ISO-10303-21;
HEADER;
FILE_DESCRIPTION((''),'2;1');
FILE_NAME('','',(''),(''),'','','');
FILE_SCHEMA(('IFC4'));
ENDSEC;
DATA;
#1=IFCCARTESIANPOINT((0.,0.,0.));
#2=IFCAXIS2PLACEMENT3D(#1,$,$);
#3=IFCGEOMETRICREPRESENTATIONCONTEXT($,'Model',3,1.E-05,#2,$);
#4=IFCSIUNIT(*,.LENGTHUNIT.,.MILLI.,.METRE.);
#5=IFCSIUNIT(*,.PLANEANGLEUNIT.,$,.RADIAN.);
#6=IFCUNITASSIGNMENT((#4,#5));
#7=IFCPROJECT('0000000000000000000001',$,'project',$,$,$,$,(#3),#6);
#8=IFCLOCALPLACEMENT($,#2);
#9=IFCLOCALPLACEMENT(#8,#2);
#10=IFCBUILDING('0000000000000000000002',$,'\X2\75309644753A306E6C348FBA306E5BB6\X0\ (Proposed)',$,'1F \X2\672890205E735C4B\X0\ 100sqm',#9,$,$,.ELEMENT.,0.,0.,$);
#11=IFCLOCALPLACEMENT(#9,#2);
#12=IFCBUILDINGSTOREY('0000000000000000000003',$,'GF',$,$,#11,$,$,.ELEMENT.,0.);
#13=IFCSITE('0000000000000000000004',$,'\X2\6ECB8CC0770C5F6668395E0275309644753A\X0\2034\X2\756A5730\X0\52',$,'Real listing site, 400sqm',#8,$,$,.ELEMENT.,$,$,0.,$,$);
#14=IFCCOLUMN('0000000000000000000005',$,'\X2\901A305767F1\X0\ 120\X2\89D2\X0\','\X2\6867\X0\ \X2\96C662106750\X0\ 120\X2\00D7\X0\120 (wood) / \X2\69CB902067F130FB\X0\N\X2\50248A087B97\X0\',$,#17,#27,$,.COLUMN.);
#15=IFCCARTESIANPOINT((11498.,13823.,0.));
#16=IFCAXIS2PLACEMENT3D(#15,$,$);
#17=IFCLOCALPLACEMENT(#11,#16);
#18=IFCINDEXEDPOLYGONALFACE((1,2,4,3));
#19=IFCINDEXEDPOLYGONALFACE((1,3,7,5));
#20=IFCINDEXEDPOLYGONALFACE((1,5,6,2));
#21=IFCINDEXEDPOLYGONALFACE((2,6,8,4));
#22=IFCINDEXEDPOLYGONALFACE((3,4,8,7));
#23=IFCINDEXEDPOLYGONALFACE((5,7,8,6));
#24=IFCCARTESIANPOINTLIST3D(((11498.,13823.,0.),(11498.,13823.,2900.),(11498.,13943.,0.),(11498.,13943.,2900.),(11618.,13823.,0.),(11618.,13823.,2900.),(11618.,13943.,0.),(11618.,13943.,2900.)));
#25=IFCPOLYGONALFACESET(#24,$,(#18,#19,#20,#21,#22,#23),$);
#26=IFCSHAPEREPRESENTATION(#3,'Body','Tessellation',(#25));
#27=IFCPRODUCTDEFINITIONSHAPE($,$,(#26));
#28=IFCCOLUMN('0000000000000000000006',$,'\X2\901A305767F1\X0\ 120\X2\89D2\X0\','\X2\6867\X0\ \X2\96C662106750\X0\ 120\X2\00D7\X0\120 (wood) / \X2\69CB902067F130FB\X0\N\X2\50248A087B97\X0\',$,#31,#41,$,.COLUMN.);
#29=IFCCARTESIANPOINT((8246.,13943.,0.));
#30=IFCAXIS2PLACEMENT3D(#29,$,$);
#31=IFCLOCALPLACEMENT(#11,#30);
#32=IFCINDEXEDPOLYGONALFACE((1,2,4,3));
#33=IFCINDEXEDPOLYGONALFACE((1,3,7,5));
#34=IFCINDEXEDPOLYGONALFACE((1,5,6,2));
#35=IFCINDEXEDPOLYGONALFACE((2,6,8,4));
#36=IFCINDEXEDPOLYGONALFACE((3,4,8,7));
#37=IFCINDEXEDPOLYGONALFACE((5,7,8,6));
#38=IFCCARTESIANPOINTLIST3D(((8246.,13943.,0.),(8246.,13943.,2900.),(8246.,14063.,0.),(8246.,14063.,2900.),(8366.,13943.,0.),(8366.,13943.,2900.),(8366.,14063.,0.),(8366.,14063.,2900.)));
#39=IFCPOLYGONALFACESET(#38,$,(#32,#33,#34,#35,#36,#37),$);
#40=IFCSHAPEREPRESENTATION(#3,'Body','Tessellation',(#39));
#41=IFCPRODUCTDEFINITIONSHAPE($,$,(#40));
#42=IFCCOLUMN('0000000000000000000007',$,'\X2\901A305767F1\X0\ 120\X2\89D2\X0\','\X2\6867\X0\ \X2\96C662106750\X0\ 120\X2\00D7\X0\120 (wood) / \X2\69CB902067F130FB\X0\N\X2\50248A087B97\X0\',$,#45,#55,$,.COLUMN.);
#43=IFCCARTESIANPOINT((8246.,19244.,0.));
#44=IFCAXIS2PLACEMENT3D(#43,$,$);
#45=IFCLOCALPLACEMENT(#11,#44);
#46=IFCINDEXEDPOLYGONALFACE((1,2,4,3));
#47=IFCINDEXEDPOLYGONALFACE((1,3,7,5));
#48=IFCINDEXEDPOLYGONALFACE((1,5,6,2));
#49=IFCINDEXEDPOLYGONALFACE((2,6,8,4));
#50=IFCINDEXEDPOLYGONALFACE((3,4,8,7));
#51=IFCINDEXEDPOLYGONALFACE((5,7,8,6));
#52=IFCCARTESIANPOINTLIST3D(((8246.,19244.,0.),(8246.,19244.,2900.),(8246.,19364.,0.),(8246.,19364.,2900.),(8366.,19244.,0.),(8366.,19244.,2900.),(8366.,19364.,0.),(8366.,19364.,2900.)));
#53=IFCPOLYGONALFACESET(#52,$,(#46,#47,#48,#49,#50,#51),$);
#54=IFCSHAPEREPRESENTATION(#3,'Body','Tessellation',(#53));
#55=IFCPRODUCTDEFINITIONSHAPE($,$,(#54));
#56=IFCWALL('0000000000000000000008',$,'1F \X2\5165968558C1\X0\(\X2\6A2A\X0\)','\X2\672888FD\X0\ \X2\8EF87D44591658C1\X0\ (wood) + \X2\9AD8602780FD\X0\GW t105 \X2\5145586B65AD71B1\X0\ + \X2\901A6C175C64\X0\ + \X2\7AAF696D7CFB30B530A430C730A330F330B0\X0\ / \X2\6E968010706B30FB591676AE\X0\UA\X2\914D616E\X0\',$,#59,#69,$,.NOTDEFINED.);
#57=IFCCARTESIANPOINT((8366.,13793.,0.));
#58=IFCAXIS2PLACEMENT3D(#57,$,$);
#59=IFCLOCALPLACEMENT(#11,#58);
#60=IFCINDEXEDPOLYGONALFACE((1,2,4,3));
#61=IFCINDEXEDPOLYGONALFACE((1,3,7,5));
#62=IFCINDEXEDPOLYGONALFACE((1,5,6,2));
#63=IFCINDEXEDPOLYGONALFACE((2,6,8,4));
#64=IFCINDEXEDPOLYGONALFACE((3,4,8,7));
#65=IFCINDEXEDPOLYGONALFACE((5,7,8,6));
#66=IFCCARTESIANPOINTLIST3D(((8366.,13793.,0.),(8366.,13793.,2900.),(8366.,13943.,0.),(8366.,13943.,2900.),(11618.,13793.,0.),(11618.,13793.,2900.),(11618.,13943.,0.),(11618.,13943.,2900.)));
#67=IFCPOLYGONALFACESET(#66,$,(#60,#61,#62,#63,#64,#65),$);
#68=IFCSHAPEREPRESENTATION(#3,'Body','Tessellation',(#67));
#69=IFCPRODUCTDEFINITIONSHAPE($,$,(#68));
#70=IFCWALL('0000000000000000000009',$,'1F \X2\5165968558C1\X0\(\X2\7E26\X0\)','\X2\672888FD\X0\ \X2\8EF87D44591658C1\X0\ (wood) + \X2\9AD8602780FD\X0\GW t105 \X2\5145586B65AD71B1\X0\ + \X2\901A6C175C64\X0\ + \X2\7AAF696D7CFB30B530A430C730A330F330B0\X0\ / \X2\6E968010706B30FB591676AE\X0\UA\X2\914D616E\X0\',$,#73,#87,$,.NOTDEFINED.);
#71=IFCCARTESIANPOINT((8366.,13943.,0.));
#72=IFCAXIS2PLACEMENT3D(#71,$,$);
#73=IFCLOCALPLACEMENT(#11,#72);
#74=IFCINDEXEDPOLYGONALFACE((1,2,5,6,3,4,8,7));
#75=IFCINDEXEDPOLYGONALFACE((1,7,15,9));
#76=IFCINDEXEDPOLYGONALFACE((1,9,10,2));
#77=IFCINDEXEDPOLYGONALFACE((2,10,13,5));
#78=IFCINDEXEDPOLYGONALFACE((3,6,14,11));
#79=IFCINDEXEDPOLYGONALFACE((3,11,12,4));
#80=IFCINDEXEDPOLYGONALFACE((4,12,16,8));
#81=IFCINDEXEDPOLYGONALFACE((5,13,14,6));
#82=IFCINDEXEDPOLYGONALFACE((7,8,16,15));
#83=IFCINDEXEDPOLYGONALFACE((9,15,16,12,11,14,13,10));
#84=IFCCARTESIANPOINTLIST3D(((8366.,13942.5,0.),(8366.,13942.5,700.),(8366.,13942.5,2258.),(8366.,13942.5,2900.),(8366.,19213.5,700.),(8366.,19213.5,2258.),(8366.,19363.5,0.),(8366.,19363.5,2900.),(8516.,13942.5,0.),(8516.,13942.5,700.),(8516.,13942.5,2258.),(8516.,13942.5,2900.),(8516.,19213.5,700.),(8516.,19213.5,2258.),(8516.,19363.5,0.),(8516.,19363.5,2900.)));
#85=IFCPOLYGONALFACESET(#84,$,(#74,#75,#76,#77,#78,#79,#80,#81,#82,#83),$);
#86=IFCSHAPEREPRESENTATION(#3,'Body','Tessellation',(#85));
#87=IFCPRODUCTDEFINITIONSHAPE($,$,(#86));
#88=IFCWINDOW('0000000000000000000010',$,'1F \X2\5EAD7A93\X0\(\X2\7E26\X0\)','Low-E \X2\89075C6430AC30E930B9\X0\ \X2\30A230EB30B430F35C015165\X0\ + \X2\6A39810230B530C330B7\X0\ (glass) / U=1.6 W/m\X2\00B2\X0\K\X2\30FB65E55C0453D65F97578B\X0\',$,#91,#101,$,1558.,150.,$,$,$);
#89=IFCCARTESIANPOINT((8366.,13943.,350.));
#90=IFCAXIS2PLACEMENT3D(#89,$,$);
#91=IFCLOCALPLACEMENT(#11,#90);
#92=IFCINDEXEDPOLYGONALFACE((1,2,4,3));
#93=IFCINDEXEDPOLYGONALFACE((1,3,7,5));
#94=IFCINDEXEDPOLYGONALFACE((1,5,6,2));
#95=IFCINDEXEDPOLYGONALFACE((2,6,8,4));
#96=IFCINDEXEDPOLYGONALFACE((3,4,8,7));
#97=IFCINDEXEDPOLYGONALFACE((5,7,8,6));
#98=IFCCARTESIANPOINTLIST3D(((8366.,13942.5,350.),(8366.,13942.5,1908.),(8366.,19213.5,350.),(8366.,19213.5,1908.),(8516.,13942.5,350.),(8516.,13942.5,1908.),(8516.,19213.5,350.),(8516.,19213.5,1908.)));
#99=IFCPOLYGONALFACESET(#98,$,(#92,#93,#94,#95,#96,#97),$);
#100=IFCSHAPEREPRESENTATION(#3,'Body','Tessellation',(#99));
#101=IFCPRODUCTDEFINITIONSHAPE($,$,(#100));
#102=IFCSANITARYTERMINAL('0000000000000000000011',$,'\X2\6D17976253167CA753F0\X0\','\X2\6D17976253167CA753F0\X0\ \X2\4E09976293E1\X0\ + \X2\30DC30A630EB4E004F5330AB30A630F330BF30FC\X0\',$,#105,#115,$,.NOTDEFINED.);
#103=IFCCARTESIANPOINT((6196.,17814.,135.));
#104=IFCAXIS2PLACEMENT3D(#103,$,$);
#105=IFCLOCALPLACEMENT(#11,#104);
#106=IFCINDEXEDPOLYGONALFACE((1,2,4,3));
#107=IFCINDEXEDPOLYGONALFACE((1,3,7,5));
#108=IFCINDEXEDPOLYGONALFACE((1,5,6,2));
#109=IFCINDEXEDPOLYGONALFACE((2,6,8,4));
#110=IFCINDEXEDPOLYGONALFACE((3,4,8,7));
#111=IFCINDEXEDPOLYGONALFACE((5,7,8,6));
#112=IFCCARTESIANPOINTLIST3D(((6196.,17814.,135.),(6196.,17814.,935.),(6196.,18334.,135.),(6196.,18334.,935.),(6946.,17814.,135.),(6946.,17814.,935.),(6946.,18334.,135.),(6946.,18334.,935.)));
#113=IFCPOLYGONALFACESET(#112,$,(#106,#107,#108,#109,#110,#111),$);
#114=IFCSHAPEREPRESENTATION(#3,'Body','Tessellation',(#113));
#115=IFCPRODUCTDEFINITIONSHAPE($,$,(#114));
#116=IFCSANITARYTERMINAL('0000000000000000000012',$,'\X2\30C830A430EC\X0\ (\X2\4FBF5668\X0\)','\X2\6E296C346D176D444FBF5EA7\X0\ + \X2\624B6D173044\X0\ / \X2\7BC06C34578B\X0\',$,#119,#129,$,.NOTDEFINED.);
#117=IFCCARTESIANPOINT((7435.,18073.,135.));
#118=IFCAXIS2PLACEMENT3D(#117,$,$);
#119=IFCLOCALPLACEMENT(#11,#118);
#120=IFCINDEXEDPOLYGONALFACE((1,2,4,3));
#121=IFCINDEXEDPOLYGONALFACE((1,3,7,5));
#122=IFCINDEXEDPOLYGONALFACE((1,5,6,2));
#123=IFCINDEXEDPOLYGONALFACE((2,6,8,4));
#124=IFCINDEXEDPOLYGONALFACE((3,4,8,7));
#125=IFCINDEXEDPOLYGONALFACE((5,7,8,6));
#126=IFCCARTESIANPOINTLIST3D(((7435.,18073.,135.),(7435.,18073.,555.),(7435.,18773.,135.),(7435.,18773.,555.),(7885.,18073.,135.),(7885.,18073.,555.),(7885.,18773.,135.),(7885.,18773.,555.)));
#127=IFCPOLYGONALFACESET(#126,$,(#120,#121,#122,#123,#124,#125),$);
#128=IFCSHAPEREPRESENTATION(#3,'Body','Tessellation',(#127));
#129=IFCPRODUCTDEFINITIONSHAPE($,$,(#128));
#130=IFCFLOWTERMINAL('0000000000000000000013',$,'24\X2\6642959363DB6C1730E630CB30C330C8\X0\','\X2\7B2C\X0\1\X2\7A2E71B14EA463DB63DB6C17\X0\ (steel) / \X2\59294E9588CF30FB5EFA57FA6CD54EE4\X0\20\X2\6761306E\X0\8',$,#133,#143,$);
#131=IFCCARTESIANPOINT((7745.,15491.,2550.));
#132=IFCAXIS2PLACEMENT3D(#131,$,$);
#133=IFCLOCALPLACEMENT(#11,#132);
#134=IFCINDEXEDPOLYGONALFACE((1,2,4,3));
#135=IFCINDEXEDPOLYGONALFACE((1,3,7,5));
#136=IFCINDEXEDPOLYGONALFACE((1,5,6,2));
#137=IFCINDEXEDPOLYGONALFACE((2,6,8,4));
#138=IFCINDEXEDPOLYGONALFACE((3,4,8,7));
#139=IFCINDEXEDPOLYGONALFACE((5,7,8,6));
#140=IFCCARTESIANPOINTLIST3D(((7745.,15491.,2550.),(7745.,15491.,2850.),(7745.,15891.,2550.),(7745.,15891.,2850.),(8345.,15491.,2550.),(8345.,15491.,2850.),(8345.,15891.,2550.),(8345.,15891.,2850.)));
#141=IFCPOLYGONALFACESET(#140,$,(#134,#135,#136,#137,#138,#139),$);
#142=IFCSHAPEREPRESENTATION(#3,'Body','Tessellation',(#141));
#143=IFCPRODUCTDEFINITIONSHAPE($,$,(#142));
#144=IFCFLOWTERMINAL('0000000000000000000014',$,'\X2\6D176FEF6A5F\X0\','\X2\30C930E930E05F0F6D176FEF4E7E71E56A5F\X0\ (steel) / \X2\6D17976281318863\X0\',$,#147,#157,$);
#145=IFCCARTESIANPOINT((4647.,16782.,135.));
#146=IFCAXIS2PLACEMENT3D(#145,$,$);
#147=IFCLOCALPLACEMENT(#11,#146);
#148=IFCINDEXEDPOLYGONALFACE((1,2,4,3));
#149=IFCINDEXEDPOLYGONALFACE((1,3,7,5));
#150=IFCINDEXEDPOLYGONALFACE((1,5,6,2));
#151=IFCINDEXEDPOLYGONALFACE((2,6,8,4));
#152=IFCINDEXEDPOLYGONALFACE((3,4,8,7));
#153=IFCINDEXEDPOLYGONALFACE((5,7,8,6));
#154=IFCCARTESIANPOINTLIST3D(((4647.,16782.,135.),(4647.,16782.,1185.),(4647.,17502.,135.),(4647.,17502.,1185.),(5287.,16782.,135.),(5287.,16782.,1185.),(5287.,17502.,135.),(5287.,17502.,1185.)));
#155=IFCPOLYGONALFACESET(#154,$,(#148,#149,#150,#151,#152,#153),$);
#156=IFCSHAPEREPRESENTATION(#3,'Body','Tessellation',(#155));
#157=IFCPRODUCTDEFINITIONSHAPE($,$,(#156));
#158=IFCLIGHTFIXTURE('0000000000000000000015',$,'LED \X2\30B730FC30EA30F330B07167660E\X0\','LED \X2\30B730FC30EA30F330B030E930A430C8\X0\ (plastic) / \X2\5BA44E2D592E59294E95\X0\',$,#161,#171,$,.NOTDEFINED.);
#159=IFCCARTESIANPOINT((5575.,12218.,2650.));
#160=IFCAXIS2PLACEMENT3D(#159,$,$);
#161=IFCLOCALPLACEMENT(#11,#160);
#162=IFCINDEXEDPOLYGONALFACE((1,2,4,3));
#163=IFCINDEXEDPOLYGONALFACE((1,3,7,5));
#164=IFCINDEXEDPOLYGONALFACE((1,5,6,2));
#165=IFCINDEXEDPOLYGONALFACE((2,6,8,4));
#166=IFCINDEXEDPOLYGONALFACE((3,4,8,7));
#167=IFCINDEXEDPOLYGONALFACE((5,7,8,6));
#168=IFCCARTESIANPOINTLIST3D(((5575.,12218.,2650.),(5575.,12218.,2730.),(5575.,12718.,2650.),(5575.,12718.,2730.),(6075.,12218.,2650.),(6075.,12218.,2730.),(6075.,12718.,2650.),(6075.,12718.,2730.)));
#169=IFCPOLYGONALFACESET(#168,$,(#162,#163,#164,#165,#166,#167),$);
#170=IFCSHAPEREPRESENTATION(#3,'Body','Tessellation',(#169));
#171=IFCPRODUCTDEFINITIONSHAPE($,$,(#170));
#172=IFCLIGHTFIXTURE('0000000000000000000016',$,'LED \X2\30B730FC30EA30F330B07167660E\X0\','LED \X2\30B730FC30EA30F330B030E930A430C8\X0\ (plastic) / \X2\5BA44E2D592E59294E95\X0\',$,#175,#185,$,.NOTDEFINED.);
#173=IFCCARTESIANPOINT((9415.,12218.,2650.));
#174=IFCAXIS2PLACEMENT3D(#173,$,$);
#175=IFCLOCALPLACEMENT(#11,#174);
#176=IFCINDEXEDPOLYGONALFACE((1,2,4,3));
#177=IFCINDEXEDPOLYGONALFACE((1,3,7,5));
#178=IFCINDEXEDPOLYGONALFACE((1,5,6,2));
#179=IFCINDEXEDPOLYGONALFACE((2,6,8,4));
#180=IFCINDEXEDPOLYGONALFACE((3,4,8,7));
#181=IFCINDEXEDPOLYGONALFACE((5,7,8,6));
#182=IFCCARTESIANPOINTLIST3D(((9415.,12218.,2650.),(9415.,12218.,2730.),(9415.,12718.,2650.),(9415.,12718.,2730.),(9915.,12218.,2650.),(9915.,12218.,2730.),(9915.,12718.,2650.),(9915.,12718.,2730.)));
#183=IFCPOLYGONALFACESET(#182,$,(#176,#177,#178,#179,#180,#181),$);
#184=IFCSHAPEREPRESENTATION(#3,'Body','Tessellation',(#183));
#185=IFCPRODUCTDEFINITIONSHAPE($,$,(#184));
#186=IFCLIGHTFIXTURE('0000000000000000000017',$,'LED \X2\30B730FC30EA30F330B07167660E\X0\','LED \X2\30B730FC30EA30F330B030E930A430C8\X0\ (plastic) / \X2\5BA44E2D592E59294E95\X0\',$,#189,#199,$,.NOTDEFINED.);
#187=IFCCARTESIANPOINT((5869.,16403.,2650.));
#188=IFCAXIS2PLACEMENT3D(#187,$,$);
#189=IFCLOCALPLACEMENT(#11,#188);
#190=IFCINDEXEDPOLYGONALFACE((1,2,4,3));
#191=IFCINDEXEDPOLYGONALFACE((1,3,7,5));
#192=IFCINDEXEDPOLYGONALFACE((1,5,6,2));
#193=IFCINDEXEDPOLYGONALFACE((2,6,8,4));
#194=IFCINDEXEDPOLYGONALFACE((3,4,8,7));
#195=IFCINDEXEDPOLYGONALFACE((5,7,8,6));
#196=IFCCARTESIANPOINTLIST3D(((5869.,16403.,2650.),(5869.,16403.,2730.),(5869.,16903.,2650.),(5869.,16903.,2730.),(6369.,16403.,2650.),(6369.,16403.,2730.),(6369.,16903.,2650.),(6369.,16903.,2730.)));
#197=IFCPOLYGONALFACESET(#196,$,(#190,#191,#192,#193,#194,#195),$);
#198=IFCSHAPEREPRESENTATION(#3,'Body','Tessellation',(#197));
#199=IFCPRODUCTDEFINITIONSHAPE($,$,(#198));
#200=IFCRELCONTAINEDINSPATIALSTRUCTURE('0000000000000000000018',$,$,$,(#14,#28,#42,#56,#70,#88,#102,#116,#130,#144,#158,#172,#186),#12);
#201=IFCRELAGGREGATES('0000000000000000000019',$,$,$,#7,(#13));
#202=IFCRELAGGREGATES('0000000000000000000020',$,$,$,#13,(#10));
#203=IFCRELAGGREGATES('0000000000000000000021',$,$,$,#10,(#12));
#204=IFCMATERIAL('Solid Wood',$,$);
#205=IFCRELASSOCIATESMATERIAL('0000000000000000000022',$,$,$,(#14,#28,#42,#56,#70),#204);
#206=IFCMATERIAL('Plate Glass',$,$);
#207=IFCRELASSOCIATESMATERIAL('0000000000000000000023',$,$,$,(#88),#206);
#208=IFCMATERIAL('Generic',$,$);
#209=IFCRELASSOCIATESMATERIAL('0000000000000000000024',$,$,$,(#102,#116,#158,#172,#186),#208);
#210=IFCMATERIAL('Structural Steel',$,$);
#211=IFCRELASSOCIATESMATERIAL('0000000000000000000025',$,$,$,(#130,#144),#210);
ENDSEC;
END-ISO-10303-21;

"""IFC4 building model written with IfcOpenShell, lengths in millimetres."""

from ifc_helpers import new_model, si_unit, frame, frame_2d, origin, place, context, project, spatial, rectangle, extrude, material, element, fill, save


model = new_model("IFC4")

# Units and contexts
model_context = context("Model", 3, precision=1e-05, world=origin())
ifc_project = project(units=[si_unit("LENGTHUNIT", "METRE", prefix="MILLI"), si_unit("PLANEANGLEUNIT", "RADIAN")], contexts=[model_context])

# Site, building, storey
site_placement = place(None, origin())
site = spatial("IfcSite", under=ifc_project, at=site_placement, Name="滋賀県彦根市田附町2034番地52", ObjectType="Real listing site, 400sqm", CompositionType="ELEMENT", RefElevation=0.0)
building_placement = place(site_placement, origin())
building = spatial("IfcBuilding", under=site, at=building_placement, Name="田附町の水辺の家 (Proposed)", ObjectType="1F 木造平屋 100sqm", CompositionType="ELEMENT", ElevationOfRefHeight=0.0, ElevationOfTerrain=0.0)
storey_placement = place(building_placement, origin())
storey = spatial("IfcBuildingStorey", under=building, at=storey_placement, Name="GF", CompositionType="ELEMENT", Elevation=0.0)

# Columns
ifc_material_1 = material(Name="Solid Wood")
column_1_placement = place(storey_placement, frame((11498.0, 13823.0, 0.0)))
element("IfcColumn", 1, at=column_1_placement, inside=storey, material=ifc_material_1, Name="通し柱 120角", Description="桧 集成材 120×120 (wood) / 構造柱・N値計算", PredefinedType="COLUMN", context=model_context, shape_type="SweptSolid", body=[
    extrude(rectangle(XDim=120.0, YDim=120.0, at=frame_2d((60.0, 60.0))), frame((11498.0, 13823.0, 0.0)), (0.0, 0.0, 1.0), 2900.0),
])
column_2_placement = place(storey_placement, frame((8246.0, 13943.0, 0.0)))
element("IfcColumn", 2, at=column_2_placement, inside=storey, material=ifc_material_1, Name="通し柱 120角", Description="桧 集成材 120×120 (wood) / 構造柱・N値計算", PredefinedType="COLUMN", context=model_context, shape_type="SweptSolid", body=[
    extrude(rectangle(XDim=120.0, YDim=120.0, at=frame_2d((60.0, 60.0))), frame((8246.0, 13943.0, 0.0)), (0.0, 0.0, 1.0), 2900.0),
])
column_3_placement = place(storey_placement, frame((8246.0, 19244.0, 0.0)))
element("IfcColumn", 3, at=column_3_placement, inside=storey, material=ifc_material_1, Name="通し柱 120角", Description="桧 集成材 120×120 (wood) / 構造柱・N値計算", PredefinedType="COLUMN", context=model_context, shape_type="SweptSolid", body=[
    extrude(rectangle(XDim=120.0, YDim=120.0, at=frame_2d((60.0, 60.0))), frame((8246.0, 19244.0, 0.0)), (0.0, 0.0, 1.0), 2900.0),
])

# Wall
wall_1_placement = place(storey_placement, frame((8366.0, 13793.0, 0.0)))
element("IfcWall", 4, at=wall_1_placement, inside=storey, material=ifc_material_1, Name="1F 入隅壁(横)", Description="木製 軸組外壁 (wood) + 高性能GW t105 充填断熱 + 通気層 + 窯業系サイディング / 準耐火・外皮UA配慮", PredefinedType="NOTDEFINED", context=model_context, shape_type="SweptSolid", body=[
    extrude(rectangle(XDim=3252.0, YDim=150.0, at=frame_2d((1626.0, 75.0))), frame((8366.0, 13793.0, 0.0)), (0.0, 0.0, 1.0), 2900.0),
])

# Wall, opening, window
wall_2_placement = place(storey_placement, frame((8366.0, 13943.0, 0.0)))
wall_2 = element("IfcWall", 5, at=wall_2_placement, inside=storey, material=ifc_material_1, Name="1F 入隅壁(縦)", Description="木製 軸組外壁 (wood) + 高性能GW t105 充填断熱 + 通気層 + 窯業系サイディング / 準耐火・外皮UA配慮", PredefinedType="NOTDEFINED", context=model_context, shape_type="SweptSolid", body=[
    extrude(rectangle(XDim=150.0, YDim=5421.0, at=frame_2d((75.0, 2710.0))), frame((8366.0, 13943.0, 0.0)), (0.0, 0.0, 1.0), 2900.0),
])
opening_placement = place(storey_placement, frame((8366.0, 13943.0, 350.0)))
opening = element("IfcOpeningElement", 6, at=opening_placement, cuts=wall_2, PredefinedType="NOTDEFINED", context=model_context, shape_type="SweptSolid", body=[
    extrude(rectangle(XDim=150.0, YDim=5271.0, at=frame_2d((75.0, 2635.0))), frame((8366.0, 13943.0, 350.0)), (0.0, 0.0, 1.0), 1558.0),
])
ifc_material_2 = material(Name="Plate Glass")
window_placement = place(storey_placement, frame((8366.0, 13943.0, 350.0)))
window = element("IfcWindow", 7, at=window_placement, inside=storey, material=ifc_material_2, Name="1F 庭窓(縦)", Description="Low-E 複層ガラス アルゴン封入 + 樹脂サッシ (glass) / U=1.6 W/m²K・日射取得型", OverallHeight=1558.0, OverallWidth=150.0, context=model_context, shape_type="SweptSolid", body=[
    extrude(rectangle(XDim=150.0, YDim=5271.0, at=frame_2d((75.0, 2635.0))), frame((8366.0, 13943.0, 350.0)), (0.0, 0.0, 1.0), 1558.0),
])
fill(opening, window)

# Sanitary terminals
ifc_material_3 = material(Name="Generic")
sanitary_terminal_1_placement = place(storey_placement, frame((6196.0, 17814.0, 135.0)))
element("IfcSanitaryTerminal", 8, at=sanitary_terminal_1_placement, inside=storey, material=ifc_material_3, Name="洗面化粧台", Description="洗面化粧台 三面鏡 + ボウル一体カウンター", PredefinedType="NOTDEFINED", context=model_context, shape_type="SweptSolid", body=[
    extrude(rectangle(XDim=750.0, YDim=520.0, at=frame_2d((375.0, 260.0))), frame((6196.0, 17814.0, 135.0)), (0.0, 0.0, 1.0), 800.0),
])
sanitary_terminal_2_placement = place(storey_placement, frame((7435.0, 18073.0, 135.0)))
element("IfcSanitaryTerminal", 9, at=sanitary_terminal_2_placement, inside=storey, material=ifc_material_3, Name="トイレ (便器)", Description="温水洗浄便座 + 手洗い / 節水型", PredefinedType="NOTDEFINED", context=model_context, shape_type="SweptSolid", body=[
    extrude(rectangle(XDim=450.0, YDim=700.0, at=frame_2d((225.0, 350.0))), frame((7435.0, 18073.0, 135.0)), (0.0, 0.0, 1.0), 420.0),
])

# Flow terminals
ifc_material_4 = material(Name="Structural Steel")
flow_terminal_1_placement = place(storey_placement, frame((7745.0, 15491.0, 2550.0)))
element("IfcFlowTerminal", 10, at=flow_terminal_1_placement, inside=storey, material=ifc_material_4, Name="24時間換気ユニット", Description="第1種熱交換換気 (steel) / 天井裏・建基法令20条の8", context=model_context, shape_type="SweptSolid", body=[
    extrude(rectangle(XDim=600.0, YDim=400.0, at=frame_2d((300.0, 200.0))), frame((7745.0, 15491.0, 2550.0)), (0.0, 0.0, 1.0), 300.0),
])
flow_terminal_2_placement = place(storey_placement, frame((4647.0, 16782.0, 135.0)))
element("IfcFlowTerminal", 11, at=flow_terminal_2_placement, inside=storey, material=ifc_material_4, Name="洗濯機", Description="ドラム式洗濯乾燥機 (steel) / 洗面脱衣", context=model_context, shape_type="SweptSolid", body=[
    extrude(rectangle(XDim=640.0, YDim=720.0, at=frame_2d((320.0, 360.0))), frame((4647.0, 16782.0, 135.0)), (0.0, 0.0, 1.0), 1050.0),
])

# Light fixtures
light_fixture_1_placement = place(storey_placement, frame((5575.0, 12218.0, 2650.0)))
element("IfcLightFixture", 12, at=light_fixture_1_placement, inside=storey, material=ifc_material_3, Name="LED シーリング照明", Description="LED シーリングライト (plastic) / 室中央天井", PredefinedType="NOTDEFINED", context=model_context, shape_type="SweptSolid", body=[
    extrude(rectangle(XDim=500.0, YDim=500.0, at=frame_2d((250.0, 250.0))), frame((5575.0, 12218.0, 2650.0)), (0.0, 0.0, 1.0), 80.0),
])
light_fixture_2_placement = place(storey_placement, frame((9415.0, 12218.0, 2650.0)))
element("IfcLightFixture", 13, at=light_fixture_2_placement, inside=storey, material=ifc_material_3, Name="LED シーリング照明", Description="LED シーリングライト (plastic) / 室中央天井", PredefinedType="NOTDEFINED", context=model_context, shape_type="SweptSolid", body=[
    extrude(rectangle(XDim=500.0, YDim=500.0, at=frame_2d((250.0, 250.0))), frame((9415.0, 12218.0, 2650.0)), (0.0, 0.0, 1.0), 80.0),
])
light_fixture_3_placement = place(storey_placement, frame((5869.0, 16403.0, 2650.0)))
element("IfcLightFixture", 14, at=light_fixture_3_placement, inside=storey, material=ifc_material_3, Name="LED シーリング照明", Description="LED シーリングライト (plastic) / 室中央天井", PredefinedType="NOTDEFINED", context=model_context, shape_type="SweptSolid", body=[
    extrude(rectangle(XDim=500.0, YDim=500.0, at=frame_2d((250.0, 250.0))), frame((5869.0, 16403.0, 2650.0)), (0.0, 0.0, 1.0), 80.0),
])

save(model, "model.ifc")
